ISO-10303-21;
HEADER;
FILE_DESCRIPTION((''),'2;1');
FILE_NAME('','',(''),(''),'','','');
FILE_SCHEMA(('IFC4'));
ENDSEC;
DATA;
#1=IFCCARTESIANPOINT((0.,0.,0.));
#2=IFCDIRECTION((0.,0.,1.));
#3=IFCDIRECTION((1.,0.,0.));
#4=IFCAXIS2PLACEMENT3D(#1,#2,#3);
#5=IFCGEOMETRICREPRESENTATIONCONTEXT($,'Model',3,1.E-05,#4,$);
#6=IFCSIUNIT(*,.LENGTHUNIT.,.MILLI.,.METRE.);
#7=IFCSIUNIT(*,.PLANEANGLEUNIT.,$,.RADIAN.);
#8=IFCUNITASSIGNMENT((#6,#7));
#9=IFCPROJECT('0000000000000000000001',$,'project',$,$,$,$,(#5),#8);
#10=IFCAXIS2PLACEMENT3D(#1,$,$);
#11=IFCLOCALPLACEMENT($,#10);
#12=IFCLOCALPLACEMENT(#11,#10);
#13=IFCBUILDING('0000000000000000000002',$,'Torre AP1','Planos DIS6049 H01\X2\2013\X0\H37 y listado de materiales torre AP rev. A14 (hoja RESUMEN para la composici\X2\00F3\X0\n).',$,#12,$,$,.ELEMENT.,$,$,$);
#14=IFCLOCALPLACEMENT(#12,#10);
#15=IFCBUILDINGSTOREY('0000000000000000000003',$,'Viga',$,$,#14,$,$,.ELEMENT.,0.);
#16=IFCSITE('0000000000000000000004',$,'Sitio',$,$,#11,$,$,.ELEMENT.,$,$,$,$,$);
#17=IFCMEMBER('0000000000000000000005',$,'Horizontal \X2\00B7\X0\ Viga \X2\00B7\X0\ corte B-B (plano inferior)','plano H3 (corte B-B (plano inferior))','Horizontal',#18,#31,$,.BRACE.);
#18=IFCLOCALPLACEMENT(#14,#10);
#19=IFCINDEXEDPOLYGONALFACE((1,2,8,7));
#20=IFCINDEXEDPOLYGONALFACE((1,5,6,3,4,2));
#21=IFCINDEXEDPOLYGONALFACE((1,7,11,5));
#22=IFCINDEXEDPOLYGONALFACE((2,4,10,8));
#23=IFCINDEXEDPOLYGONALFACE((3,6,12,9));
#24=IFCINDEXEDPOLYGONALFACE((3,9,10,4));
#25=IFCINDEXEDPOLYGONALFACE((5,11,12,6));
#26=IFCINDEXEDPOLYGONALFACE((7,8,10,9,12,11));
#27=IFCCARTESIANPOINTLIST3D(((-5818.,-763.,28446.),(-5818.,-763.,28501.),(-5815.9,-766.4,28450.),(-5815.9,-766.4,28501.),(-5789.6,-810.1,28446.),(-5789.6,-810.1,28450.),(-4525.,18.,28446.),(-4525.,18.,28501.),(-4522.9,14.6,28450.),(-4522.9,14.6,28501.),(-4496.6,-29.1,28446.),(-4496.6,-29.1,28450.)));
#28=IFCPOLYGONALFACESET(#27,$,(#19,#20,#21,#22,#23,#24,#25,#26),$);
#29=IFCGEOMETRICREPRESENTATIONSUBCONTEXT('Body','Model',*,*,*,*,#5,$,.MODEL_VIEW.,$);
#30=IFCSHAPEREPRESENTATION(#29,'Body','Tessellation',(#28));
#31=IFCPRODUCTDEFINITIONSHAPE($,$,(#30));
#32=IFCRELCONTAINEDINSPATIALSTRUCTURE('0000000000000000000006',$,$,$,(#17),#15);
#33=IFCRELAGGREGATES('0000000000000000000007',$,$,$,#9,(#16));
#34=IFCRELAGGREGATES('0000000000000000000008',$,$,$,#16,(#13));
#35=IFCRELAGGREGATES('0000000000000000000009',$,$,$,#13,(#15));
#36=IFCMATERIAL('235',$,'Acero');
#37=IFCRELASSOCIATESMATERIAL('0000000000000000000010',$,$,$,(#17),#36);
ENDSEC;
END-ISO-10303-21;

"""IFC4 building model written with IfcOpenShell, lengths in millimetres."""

from ifc_helpers import new_model, si_unit, frame, frame_2d, origin, origin_with_axes, place, context, subcontext, project, spatial, l_section, extrude, material, element, save


model = new_model("IFC4")

# Units and contexts
model_context = context("Model", 3, precision=1e-05, world=origin_with_axes())
body_context = subcontext(model_context, "Body", "Model", "MODEL_VIEW")
ifc_project = project(units=[si_unit("LENGTHUNIT", "METRE", prefix="MILLI"), si_unit("PLANEANGLEUNIT", "RADIAN")], contexts=[model_context])

# Site, building, storey
site_placement = place(None, origin())
site = spatial("IfcSite", under=ifc_project, at=site_placement, Name="Sitio", CompositionType="ELEMENT")
building_placement = place(site_placement, origin())
building = spatial("IfcBuilding", under=site, at=building_placement, Name="Torre AP1", Description="Planos DIS6049 H01–H37 y listado de materiales torre AP rev. A14 (hoja RESUMEN para la composición).", CompositionType="ELEMENT")
storey_placement = place(building_placement, origin())
storey = spatial("IfcBuildingStorey", under=building, at=storey_placement, Name="Viga", CompositionType="ELEMENT", Elevation=0.0)

# Member
ifc_material = material(Name="235", Category="Acero")
member_1_placement = place(storey_placement, frame((-4525.0, 18.0, 28446.0), z_axis=(-0.85597, -0.517025, 0.0), x_axis=(0.517025, -0.85597, 0.0)))
element("IfcMember", 1, at=member_1_placement, inside=storey, material=ifc_material, Name="Horizontal · Viga · corte B-B (plano inferior)", Description="plano H3 (corte B-B (plano inferior))", ObjectType="Horizontal", PredefinedType="BRACE", context=body_context, shape_type="SweptSolid", body=[
    extrude(l_section(Depth=55.0, Width=55.0, Thickness=4.0, at=frame_2d((27.5, 27.5))), None, (0.0, 0.0, 1.0), 1510.6),
])

save(model, "model.ifc")
